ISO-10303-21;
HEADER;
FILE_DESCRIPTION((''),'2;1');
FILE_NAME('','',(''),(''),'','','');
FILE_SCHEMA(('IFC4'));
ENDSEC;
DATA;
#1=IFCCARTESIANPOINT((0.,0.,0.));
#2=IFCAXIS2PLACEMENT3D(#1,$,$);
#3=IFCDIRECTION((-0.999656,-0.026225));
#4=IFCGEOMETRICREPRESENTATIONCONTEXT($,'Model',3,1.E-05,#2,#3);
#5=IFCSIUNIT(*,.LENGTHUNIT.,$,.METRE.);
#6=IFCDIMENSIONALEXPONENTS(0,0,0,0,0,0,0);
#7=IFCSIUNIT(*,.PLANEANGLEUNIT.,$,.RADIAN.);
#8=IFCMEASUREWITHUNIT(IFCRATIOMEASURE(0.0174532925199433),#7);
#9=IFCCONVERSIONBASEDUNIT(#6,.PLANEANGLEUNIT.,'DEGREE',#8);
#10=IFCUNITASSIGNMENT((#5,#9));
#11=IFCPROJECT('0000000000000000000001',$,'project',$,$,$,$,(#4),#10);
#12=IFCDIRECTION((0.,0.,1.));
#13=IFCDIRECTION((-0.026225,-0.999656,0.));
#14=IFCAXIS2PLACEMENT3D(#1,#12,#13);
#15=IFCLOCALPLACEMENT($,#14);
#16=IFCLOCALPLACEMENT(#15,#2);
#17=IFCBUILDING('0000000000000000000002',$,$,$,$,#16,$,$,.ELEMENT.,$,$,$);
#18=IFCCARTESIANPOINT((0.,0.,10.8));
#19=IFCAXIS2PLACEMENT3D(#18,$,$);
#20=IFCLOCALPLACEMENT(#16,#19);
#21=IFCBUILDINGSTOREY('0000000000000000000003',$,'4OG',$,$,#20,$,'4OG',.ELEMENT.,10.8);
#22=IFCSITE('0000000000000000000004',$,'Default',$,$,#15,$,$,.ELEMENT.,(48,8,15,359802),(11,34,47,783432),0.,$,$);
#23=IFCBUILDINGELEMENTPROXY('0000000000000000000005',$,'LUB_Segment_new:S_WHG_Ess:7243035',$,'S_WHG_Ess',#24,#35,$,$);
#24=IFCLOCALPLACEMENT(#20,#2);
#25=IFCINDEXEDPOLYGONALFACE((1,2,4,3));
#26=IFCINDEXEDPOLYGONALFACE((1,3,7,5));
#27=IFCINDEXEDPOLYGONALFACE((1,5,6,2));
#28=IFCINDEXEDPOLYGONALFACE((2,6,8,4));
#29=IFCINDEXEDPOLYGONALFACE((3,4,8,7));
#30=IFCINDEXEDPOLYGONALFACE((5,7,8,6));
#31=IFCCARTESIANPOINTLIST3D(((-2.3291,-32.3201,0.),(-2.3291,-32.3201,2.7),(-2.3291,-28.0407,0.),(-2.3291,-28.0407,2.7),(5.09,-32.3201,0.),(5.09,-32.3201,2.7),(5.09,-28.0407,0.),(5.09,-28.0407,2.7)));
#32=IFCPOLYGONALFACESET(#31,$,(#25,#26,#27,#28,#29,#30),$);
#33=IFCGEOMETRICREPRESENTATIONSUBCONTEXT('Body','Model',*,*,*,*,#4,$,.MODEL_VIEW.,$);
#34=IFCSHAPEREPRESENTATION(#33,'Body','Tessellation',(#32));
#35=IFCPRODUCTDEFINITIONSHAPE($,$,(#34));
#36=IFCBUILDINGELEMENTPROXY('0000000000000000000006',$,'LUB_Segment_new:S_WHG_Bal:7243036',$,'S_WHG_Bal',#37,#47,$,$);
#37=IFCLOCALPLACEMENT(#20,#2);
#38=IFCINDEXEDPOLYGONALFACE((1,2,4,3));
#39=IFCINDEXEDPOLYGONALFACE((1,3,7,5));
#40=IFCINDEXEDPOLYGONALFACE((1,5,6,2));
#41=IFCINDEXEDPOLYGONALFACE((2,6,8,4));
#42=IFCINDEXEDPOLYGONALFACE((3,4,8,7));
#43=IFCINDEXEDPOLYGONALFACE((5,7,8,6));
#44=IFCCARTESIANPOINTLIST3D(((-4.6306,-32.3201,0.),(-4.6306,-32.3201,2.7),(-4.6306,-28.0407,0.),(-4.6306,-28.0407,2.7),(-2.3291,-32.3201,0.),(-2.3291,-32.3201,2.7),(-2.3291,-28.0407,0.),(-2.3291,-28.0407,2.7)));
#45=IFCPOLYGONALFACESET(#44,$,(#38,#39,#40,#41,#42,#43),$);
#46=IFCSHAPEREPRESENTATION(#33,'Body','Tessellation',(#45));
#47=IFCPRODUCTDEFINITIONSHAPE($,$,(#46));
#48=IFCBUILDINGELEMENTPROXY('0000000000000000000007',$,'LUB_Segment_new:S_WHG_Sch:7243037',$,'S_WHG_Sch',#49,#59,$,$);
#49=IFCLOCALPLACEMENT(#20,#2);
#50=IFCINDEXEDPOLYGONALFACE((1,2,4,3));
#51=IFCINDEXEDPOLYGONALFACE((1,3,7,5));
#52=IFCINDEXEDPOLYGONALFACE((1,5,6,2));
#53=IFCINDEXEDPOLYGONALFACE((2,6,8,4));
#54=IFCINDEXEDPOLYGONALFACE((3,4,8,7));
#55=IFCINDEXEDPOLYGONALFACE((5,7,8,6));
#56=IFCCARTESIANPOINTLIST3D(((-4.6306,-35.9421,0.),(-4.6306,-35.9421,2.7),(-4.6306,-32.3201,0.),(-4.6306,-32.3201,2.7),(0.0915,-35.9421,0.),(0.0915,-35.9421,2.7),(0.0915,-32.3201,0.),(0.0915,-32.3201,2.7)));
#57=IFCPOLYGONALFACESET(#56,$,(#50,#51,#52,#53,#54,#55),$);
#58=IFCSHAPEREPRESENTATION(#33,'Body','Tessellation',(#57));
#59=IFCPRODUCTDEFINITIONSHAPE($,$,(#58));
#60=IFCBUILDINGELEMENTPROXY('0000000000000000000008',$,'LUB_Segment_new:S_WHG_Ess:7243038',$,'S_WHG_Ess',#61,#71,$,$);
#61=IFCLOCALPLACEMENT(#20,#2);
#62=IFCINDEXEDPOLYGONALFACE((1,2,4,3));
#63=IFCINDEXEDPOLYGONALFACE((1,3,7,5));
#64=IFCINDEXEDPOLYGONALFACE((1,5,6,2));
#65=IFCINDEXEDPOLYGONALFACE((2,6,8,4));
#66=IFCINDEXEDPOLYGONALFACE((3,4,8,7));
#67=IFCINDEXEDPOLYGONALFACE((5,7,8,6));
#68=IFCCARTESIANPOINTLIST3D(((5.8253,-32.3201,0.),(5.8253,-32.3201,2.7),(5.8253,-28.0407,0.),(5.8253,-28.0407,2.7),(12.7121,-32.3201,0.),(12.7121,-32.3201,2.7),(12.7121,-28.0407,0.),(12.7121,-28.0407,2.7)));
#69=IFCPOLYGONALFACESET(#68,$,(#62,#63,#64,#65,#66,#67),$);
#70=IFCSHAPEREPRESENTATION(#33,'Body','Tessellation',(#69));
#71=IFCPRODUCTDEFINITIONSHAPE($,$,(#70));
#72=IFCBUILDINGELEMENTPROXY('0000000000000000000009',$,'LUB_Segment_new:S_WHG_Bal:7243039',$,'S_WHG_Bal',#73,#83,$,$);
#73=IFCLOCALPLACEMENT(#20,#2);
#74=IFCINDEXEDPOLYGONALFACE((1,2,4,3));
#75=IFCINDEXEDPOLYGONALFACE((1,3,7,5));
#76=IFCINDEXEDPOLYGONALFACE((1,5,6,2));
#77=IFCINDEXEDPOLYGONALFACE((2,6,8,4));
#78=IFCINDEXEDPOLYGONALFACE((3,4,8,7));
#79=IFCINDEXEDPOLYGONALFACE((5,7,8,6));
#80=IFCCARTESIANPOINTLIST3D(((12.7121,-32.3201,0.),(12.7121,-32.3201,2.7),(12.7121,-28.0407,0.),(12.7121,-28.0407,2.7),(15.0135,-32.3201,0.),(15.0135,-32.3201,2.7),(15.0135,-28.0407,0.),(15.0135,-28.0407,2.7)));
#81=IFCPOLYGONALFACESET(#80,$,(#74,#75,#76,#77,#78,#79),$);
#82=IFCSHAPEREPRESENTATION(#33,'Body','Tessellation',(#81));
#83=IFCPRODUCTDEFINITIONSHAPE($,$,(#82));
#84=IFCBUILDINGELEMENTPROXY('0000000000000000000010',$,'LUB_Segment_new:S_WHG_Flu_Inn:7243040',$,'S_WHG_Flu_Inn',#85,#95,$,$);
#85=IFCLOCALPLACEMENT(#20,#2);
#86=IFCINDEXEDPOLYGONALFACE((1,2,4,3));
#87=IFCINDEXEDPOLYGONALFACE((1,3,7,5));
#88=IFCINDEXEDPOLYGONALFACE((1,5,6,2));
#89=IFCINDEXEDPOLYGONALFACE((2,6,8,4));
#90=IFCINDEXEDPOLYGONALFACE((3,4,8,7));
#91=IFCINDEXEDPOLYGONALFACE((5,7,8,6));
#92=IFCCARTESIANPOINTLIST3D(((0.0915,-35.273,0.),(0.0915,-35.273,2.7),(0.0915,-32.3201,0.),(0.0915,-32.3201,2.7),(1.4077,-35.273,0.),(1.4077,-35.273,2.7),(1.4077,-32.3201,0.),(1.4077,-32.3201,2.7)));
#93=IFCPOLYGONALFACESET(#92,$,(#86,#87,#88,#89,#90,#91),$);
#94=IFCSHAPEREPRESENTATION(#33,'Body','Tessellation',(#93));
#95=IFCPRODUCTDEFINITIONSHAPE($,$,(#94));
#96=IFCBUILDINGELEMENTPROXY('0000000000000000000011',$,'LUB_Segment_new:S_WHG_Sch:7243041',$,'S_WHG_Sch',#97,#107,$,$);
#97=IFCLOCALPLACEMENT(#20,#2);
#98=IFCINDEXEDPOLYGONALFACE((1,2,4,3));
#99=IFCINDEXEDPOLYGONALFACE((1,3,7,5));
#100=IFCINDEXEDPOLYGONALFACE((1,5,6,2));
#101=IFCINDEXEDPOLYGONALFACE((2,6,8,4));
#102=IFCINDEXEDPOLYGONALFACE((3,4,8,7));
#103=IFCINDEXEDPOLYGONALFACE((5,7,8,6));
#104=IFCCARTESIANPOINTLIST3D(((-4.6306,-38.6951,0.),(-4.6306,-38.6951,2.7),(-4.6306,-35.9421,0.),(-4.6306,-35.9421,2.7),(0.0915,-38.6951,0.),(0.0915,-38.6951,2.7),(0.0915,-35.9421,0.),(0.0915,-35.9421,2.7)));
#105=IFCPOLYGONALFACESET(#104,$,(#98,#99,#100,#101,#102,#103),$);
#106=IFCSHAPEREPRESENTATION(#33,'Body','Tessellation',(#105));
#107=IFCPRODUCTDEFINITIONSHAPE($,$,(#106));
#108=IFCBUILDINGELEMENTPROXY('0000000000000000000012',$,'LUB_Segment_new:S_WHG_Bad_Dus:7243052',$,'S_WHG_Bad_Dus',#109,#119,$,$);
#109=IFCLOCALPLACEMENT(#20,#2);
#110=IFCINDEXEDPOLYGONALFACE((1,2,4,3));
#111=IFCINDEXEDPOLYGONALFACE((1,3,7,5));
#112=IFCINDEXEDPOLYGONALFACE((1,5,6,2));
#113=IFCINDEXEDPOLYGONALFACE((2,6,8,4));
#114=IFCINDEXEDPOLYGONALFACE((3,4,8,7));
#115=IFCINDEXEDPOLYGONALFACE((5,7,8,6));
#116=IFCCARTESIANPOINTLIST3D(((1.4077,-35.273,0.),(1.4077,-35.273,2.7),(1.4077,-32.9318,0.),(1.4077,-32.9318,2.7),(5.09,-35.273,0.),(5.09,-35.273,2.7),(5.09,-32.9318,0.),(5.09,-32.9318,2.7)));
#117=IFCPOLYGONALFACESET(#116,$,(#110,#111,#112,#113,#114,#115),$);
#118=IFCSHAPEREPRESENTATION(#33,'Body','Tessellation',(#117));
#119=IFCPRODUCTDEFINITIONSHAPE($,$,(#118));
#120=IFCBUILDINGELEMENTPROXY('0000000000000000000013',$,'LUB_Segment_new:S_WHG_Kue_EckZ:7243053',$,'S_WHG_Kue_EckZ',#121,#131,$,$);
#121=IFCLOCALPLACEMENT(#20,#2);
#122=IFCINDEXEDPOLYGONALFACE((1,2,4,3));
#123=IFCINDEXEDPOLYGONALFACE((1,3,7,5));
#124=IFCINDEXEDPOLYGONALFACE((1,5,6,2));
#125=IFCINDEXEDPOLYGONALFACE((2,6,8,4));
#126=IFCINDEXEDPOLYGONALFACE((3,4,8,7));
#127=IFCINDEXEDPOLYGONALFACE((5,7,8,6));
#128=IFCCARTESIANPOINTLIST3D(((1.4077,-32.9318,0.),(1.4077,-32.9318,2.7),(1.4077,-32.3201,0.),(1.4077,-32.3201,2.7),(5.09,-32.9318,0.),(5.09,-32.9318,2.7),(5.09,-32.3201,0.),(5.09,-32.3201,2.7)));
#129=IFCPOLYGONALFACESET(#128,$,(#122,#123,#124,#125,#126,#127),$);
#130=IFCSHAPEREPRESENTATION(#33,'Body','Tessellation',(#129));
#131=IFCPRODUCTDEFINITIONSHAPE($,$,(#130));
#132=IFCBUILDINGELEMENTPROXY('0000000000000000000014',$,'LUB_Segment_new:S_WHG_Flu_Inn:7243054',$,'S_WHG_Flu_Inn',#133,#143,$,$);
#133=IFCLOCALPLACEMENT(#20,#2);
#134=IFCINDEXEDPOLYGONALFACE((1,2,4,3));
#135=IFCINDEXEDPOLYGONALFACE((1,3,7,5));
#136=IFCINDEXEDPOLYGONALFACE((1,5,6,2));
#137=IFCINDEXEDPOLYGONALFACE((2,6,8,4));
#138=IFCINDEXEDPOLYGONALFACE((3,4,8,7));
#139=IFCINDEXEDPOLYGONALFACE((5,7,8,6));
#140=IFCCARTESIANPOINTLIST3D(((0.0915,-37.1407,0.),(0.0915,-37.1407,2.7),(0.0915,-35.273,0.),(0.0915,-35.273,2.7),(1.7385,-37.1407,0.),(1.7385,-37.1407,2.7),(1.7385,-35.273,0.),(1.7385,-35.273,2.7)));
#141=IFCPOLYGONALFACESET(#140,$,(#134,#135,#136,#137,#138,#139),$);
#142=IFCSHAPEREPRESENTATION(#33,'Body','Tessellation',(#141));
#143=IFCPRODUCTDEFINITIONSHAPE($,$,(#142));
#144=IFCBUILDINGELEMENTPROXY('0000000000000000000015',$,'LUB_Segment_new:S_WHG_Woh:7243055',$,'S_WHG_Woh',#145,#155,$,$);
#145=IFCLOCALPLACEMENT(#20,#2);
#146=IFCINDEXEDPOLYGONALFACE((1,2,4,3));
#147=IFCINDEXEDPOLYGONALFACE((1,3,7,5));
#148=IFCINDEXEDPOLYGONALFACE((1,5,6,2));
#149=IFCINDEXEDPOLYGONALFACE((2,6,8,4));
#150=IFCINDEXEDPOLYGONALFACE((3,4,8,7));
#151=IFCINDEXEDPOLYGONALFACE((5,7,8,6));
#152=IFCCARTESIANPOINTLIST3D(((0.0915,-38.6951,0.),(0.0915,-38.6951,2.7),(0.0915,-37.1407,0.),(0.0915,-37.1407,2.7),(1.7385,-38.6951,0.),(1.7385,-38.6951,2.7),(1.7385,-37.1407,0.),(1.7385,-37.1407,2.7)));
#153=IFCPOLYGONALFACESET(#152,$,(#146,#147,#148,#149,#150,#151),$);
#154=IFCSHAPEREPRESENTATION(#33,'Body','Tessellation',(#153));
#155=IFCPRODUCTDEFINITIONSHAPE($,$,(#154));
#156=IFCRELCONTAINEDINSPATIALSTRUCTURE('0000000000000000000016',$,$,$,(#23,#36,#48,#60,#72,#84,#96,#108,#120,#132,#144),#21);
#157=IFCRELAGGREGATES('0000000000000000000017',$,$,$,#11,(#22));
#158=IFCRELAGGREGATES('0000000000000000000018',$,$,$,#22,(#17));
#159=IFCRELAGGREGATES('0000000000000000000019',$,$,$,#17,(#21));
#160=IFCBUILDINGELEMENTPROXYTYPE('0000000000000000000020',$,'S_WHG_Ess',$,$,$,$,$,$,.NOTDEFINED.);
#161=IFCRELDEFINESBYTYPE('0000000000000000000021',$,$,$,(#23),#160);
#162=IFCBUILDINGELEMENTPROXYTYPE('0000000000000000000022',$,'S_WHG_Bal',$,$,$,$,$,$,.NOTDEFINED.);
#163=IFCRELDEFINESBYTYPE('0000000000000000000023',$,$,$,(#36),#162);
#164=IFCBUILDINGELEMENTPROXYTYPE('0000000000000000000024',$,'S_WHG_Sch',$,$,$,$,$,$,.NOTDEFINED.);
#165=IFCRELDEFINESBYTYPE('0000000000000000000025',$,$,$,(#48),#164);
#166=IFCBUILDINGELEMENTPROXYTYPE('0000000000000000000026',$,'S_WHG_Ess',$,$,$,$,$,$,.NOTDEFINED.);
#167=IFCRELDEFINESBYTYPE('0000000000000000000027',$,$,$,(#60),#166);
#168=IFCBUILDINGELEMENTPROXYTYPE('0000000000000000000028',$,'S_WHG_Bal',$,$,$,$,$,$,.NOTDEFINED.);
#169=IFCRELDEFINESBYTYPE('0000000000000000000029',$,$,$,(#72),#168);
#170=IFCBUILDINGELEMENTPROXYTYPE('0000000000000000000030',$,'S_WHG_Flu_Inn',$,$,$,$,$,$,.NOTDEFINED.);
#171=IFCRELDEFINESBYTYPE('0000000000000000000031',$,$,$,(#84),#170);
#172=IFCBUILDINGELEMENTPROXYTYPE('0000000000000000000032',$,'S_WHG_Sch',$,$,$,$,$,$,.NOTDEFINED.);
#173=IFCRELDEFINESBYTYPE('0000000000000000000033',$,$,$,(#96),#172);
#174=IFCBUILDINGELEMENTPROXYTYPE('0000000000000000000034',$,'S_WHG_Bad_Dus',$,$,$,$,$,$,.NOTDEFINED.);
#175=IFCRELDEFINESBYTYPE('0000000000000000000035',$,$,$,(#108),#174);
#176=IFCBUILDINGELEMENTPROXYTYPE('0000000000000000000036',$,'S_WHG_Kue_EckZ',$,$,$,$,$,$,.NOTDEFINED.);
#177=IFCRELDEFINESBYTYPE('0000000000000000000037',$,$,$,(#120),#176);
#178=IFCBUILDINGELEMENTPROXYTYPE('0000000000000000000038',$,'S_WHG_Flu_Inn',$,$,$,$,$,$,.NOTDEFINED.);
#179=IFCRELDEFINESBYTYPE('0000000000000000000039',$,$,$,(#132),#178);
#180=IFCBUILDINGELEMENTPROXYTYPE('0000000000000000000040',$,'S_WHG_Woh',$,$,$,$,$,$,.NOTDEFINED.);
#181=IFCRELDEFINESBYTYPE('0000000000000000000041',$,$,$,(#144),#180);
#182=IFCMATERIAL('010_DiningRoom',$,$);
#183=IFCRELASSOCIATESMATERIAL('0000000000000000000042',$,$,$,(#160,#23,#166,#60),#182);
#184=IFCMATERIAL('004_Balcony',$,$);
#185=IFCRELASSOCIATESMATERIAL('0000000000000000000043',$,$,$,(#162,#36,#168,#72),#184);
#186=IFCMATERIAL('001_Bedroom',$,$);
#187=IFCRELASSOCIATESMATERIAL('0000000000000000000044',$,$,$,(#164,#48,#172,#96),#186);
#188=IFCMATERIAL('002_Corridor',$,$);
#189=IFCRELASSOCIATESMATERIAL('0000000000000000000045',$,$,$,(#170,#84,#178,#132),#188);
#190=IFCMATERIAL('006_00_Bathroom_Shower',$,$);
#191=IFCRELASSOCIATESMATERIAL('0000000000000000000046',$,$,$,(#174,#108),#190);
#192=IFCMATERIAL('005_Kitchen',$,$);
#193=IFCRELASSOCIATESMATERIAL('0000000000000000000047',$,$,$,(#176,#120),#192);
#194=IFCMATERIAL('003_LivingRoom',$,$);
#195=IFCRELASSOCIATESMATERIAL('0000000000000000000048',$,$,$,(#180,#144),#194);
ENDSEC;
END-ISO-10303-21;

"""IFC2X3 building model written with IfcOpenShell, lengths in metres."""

from ifc_helpers import new_model, entity, si_unit, converted_unit, direction, frame, origin, origin_2d_with_axis, place, context, subcontext, project, spatial, rectangle, extrude, source, transform, mapped, material, type_object, type_shapes, element, save


model = new_model("IFC2X3")

# Units and contexts
model_context = context("Model", 3, precision=1e-05, world=origin(), true_north=direction((-0.999656, -0.026225)))
body_context = subcontext(model_context, "Body", "Model", "MODEL_VIEW")
ifc_project = project(units=[si_unit("LENGTHUNIT", "METRE"), converted_unit("PLANEANGLEUNIT", "DEGREE", entity("IfcRatioMeasure", 0.0174532925199433), si_unit("PLANEANGLEUNIT", "RADIAN"), dimensions=[0, 0, 0, 0, 0, 0, 0])], contexts=[model_context])

# Site, building, storey
site_placement = place(None, frame((0.0, 0.0, 0.0), z_axis=(0.0, 0.0, 1.0), x_axis=(-0.026225, -0.999656, 0.0)))
site = spatial("IfcSite", under=ifc_project, at=site_placement, Name="Default", CompositionType="ELEMENT", RefLatitude=(48, 8, 15, 359802), RefLongitude=(11, 34, 47, 783432), RefElevation=0.0)
building_placement = place(site_placement, origin())
building = spatial("IfcBuilding", under=site, at=building_placement, CompositionType="ELEMENT")
storey_placement = place(building_placement, frame((0.0, 0.0, 10.8)))
storey = spatial("IfcBuildingStorey", under=building, at=storey_placement, Name="4OG", LongName="4OG", CompositionType="ELEMENT", Elevation=10.8)

# Building element proxies
ifc_material_1 = material(Name="010_DiningRoom")
building_element_proxy_type_1 = type_object("IfcBuildingElementProxyType", Name="S_WHG_Ess", PredefinedType="NOTDEFINED", material=ifc_material_1)
shared_shape_1 = source(origin(), body_context, "Body", "SweptSolid", [
    extrude(rectangle(XDim=7.4191, YDim=4.2794, at=origin_2d_with_axis()), frame((0.0, 0.0, 0.0), z_axis=(0.0, 0.0, 1.0), x_axis=(-1.0, 0.0, 0.0)), (0.0, 0.0, 1.0), 2.7),
])
type_shapes(building_element_proxy_type_1, [shared_shape_1])
proxy_1_placement = place(storey_placement, frame((1.3805, -30.1804, 0.0)))
element("IfcBuildingElementProxy", 1, at=proxy_1_placement, inside=storey, type_object=building_element_proxy_type_1, material=ifc_material_1, Name="LUB_Segment_new:S_WHG_Ess:7243035", ObjectType="S_WHG_Ess", context=body_context, shape_type="MappedRepresentation", body=[
    mapped(shared_shape_1, transform((0.0, 0.0, 0.0), scale=1.0)),
])
ifc_material_2 = material(Name="004_Balcony")
building_element_proxy_type_2 = type_object("IfcBuildingElementProxyType", Name="S_WHG_Bal", PredefinedType="NOTDEFINED", material=ifc_material_2)
shared_shape_2 = source(origin(), body_context, "Body", "SweptSolid", [
    extrude(rectangle(XDim=2.3015, YDim=4.2794, at=origin_2d_with_axis()), frame((0.0, 0.0, 0.0), z_axis=(0.0, 0.0, 1.0), x_axis=(-1.0, 0.0, 0.0)), (0.0, 0.0, 1.0), 2.7),
])
type_shapes(building_element_proxy_type_2, [shared_shape_2])
proxy_2_placement = place(storey_placement, frame((-3.4798, -30.1804, 0.0)))
element("IfcBuildingElementProxy", 2, at=proxy_2_placement, inside=storey, type_object=building_element_proxy_type_2, material=ifc_material_2, Name="LUB_Segment_new:S_WHG_Bal:7243036", ObjectType="S_WHG_Bal", context=body_context, shape_type="MappedRepresentation", body=[
    mapped(shared_shape_2, transform((0.0, 0.0, 0.0), scale=1.0)),
])
ifc_material_3 = material(Name="001_Bedroom")
building_element_proxy_type_3 = type_object("IfcBuildingElementProxyType", Name="S_WHG_Sch", PredefinedType="NOTDEFINED", material=ifc_material_3)
shared_shape_3 = source(origin(), body_context, "Body", "SweptSolid", [
    extrude(rectangle(XDim=4.7221, YDim=3.6221, at=origin_2d_with_axis()), frame((0.0, 0.0, 0.0), z_axis=(0.0, 0.0, 1.0), x_axis=(-1.0, 0.0, 0.0)), (0.0, 0.0, 1.0), 2.7),
])
type_shapes(building_element_proxy_type_3, [shared_shape_3])
proxy_3_placement = place(storey_placement, frame((-2.2695, -34.1311, 0.0)))
element("IfcBuildingElementProxy", 3, at=proxy_3_placement, inside=storey, type_object=building_element_proxy_type_3, material=ifc_material_3, Name="LUB_Segment_new:S_WHG_Sch:7243037", ObjectType="S_WHG_Sch", context=body_context, shape_type="MappedRepresentation", body=[
    mapped(shared_shape_3, transform((0.0, 0.0, 0.0), scale=1.0)),
])
building_element_proxy_type_4 = type_object("IfcBuildingElementProxyType", Name="S_WHG_Ess", PredefinedType="NOTDEFINED", material=ifc_material_1)
shared_shape_4 = source(origin(), body_context, "Body", "SweptSolid", [
    extrude(rectangle(XDim=6.8868, YDim=4.2794, at=origin_2d_with_axis()), frame((0.0, 0.0, 0.0), z_axis=(0.0, 0.0, 1.0), x_axis=(-1.0, 0.0, 0.0)), (0.0, 0.0, 1.0), 2.7),
])
type_shapes(building_element_proxy_type_4, [shared_shape_4])
proxy_4_placement = place(storey_placement, frame((9.2687, -30.1804, 0.0)))
element("IfcBuildingElementProxy", 4, at=proxy_4_placement, inside=storey, type_object=building_element_proxy_type_4, material=ifc_material_1, Name="LUB_Segment_new:S_WHG_Ess:7243038", ObjectType="S_WHG_Ess", context=body_context, shape_type="MappedRepresentation", body=[
    mapped(shared_shape_4, transform((0.0, 0.0, 0.0), scale=1.0)),
])
building_element_proxy_type_5 = type_object("IfcBuildingElementProxyType", Name="S_WHG_Bal", PredefinedType="NOTDEFINED", material=ifc_material_2)
shared_shape_5 = source(origin(), body_context, "Body", "SweptSolid", [
    extrude(rectangle(XDim=4.2794, YDim=2.3015, at=origin_2d_with_axis()), frame((0.0, 0.0, 0.0), z_axis=(0.0, 0.0, 1.0), x_axis=(0.0, 1.0, 0.0)), (0.0, 0.0, 1.0), 2.7),
])
type_shapes(building_element_proxy_type_5, [shared_shape_5])
proxy_5_placement = place(storey_placement, frame((13.8628, -30.1804, 0.0), z_axis=(0.0, 0.0, 1.0), x_axis=(-1.0, 0.0, 0.0)))
element("IfcBuildingElementProxy", 5, at=proxy_5_placement, inside=storey, type_object=building_element_proxy_type_5, material=ifc_material_2, Name="LUB_Segment_new:S_WHG_Bal:7243039", ObjectType="S_WHG_Bal", context=body_context, shape_type="MappedRepresentation", body=[
    mapped(shared_shape_5, transform((0.0, 0.0, 0.0), scale=1.0)),
])
ifc_material_4 = material(Name="002_Corridor")
building_element_proxy_type_6 = type_object("IfcBuildingElementProxyType", Name="S_WHG_Flu_Inn", PredefinedType="NOTDEFINED", material=ifc_material_4)
shared_shape_6 = source(origin(), body_context, "Body", "SweptSolid", [
    extrude(rectangle(XDim=1.3162, YDim=2.9529, at=origin_2d_with_axis()), frame((0.0, 0.0, 0.0), z_axis=(0.0, 0.0, 1.0), x_axis=(-1.0, 0.0, 0.0)), (0.0, 0.0, 1.0), 2.7),
])
type_shapes(building_element_proxy_type_6, [shared_shape_6])
proxy_6_placement = place(storey_placement, frame((0.7496, -33.7966, 0.0)))
element("IfcBuildingElementProxy", 6, at=proxy_6_placement, inside=storey, type_object=building_element_proxy_type_6, material=ifc_material_4, Name="LUB_Segment_new:S_WHG_Flu_Inn:7243040", ObjectType="S_WHG_Flu_Inn", context=body_context, shape_type="MappedRepresentation", body=[
    mapped(shared_shape_6, transform((0.0, 0.0, 0.0), scale=1.0)),
])
building_element_proxy_type_7 = type_object("IfcBuildingElementProxyType", Name="S_WHG_Sch", PredefinedType="NOTDEFINED", material=ifc_material_3)
shared_shape_7 = source(origin(), body_context, "Body", "SweptSolid", [
    extrude(rectangle(XDim=4.7221, YDim=2.7529, at=origin_2d_with_axis()), frame((0.0, 0.0, 0.0), z_axis=(0.0, 0.0, 1.0), x_axis=(-1.0, 0.0, 0.0)), (0.0, 0.0, 1.0), 2.7),
])
type_shapes(building_element_proxy_type_7, [shared_shape_7])
proxy_7_placement = place(storey_placement, frame((-2.2695, -37.3186, 0.0)))
element("IfcBuildingElementProxy", 7, at=proxy_7_placement, inside=storey, type_object=building_element_proxy_type_7, material=ifc_material_3, Name="LUB_Segment_new:S_WHG_Sch:7243041", ObjectType="S_WHG_Sch", context=body_context, shape_type="MappedRepresentation", body=[
    mapped(shared_shape_7, transform((0.0, 0.0, 0.0), scale=1.0)),
])
ifc_material_5 = material(Name="006_00_Bathroom_Shower")
building_element_proxy_type_8 = type_object("IfcBuildingElementProxyType", Name="S_WHG_Bad_Dus", PredefinedType="NOTDEFINED", material=ifc_material_5)
shared_shape_8 = source(origin(), body_context, "Body", "SweptSolid", [
    extrude(rectangle(XDim=2.3412, YDim=3.6824, at=origin_2d_with_axis()), frame((0.0, 0.0, 0.0), z_axis=(0.0, 0.0, 1.0), x_axis=(0.0, 1.0, 0.0)), (0.0, 0.0, 1.0), 2.7),
])
type_shapes(building_element_proxy_type_8, [shared_shape_8])
proxy_8_placement = place(storey_placement, frame((3.2488, -34.1024, 0.0)))
element("IfcBuildingElementProxy", 8, at=proxy_8_placement, inside=storey, type_object=building_element_proxy_type_8, material=ifc_material_5, Name="LUB_Segment_new:S_WHG_Bad_Dus:7243052", ObjectType="S_WHG_Bad_Dus", context=body_context, shape_type="MappedRepresentation", body=[
    mapped(shared_shape_8, transform((0.0, 0.0, 0.0), scale=1.0)),
])
ifc_material_6 = material(Name="005_Kitchen")
building_element_proxy_type_9 = type_object("IfcBuildingElementProxyType", Name="S_WHG_Kue_EckZ", PredefinedType="NOTDEFINED", material=ifc_material_6)
shared_shape_9 = source(origin(), body_context, "Body", "SweptSolid", [
    extrude(rectangle(XDim=0.6118, YDim=3.6824, at=origin_2d_with_axis()), frame((0.0, 0.0, 0.0), z_axis=(0.0, 0.0, 1.0), x_axis=(0.0, 1.0, 0.0)), (0.0, 0.0, 1.0), 2.7),
])
type_shapes(building_element_proxy_type_9, [shared_shape_9])
proxy_9_placement = place(storey_placement, frame((3.2488, -32.626, 0.0)))
element("IfcBuildingElementProxy", 9, at=proxy_9_placement, inside=storey, type_object=building_element_proxy_type_9, material=ifc_material_6, Name="LUB_Segment_new:S_WHG_Kue_EckZ:7243053", ObjectType="S_WHG_Kue_EckZ", context=body_context, shape_type="MappedRepresentation", body=[
    mapped(shared_shape_9, transform((0.0, 0.0, 0.0), scale=1.0)),
])
building_element_proxy_type_10 = type_object("IfcBuildingElementProxyType", Name="S_WHG_Flu_Inn", PredefinedType="NOTDEFINED", material=ifc_material_4)
shared_shape_10 = source(origin(), body_context, "Body", "SweptSolid", [
    extrude(rectangle(XDim=1.6471, YDim=1.8676, at=origin_2d_with_axis()), frame((0.0, 0.0, 0.0), z_axis=(0.0, 0.0, 1.0), x_axis=(-1.0, 0.0, 0.0)), (0.0, 0.0, 1.0), 2.7),
])
type_shapes(building_element_proxy_type_10, [shared_shape_10])
proxy_10_placement = place(storey_placement, frame((0.915, -36.2068, 0.0)))
element("IfcBuildingElementProxy", 10, at=proxy_10_placement, inside=storey, type_object=building_element_proxy_type_10, material=ifc_material_4, Name="LUB_Segment_new:S_WHG_Flu_Inn:7243054", ObjectType="S_WHG_Flu_Inn", context=body_context, shape_type="MappedRepresentation", body=[
    mapped(shared_shape_10, transform((0.0, 0.0, 0.0), scale=1.0)),
])
ifc_material_7 = material(Name="003_LivingRoom")
building_element_proxy_type_11 = type_object("IfcBuildingElementProxyType", Name="S_WHG_Woh", PredefinedType="NOTDEFINED", material=ifc_material_7)
shared_shape_11 = source(origin(), body_context, "Body", "SweptSolid", [
    extrude(rectangle(XDim=1.6471, YDim=1.5544, at=origin_2d_with_axis()), frame((0.0, 0.0, 0.0), z_axis=(0.0, 0.0, 1.0), x_axis=(-1.0, 0.0, 0.0)), (0.0, 0.0, 1.0), 2.7),
])
type_shapes(building_element_proxy_type_11, [shared_shape_11])
proxy_11_placement = place(storey_placement, frame((0.915, -37.9179, 0.0)))
element("IfcBuildingElementProxy", 11, at=proxy_11_placement, inside=storey, type_object=building_element_proxy_type_11, material=ifc_material_7, Name="LUB_Segment_new:S_WHG_Woh:7243055", ObjectType="S_WHG_Woh", context=body_context, shape_type="MappedRepresentation", body=[
    mapped(shared_shape_11, transform((0.0, 0.0, 0.0), scale=1.0)),
])

save(model, "model.ifc")
